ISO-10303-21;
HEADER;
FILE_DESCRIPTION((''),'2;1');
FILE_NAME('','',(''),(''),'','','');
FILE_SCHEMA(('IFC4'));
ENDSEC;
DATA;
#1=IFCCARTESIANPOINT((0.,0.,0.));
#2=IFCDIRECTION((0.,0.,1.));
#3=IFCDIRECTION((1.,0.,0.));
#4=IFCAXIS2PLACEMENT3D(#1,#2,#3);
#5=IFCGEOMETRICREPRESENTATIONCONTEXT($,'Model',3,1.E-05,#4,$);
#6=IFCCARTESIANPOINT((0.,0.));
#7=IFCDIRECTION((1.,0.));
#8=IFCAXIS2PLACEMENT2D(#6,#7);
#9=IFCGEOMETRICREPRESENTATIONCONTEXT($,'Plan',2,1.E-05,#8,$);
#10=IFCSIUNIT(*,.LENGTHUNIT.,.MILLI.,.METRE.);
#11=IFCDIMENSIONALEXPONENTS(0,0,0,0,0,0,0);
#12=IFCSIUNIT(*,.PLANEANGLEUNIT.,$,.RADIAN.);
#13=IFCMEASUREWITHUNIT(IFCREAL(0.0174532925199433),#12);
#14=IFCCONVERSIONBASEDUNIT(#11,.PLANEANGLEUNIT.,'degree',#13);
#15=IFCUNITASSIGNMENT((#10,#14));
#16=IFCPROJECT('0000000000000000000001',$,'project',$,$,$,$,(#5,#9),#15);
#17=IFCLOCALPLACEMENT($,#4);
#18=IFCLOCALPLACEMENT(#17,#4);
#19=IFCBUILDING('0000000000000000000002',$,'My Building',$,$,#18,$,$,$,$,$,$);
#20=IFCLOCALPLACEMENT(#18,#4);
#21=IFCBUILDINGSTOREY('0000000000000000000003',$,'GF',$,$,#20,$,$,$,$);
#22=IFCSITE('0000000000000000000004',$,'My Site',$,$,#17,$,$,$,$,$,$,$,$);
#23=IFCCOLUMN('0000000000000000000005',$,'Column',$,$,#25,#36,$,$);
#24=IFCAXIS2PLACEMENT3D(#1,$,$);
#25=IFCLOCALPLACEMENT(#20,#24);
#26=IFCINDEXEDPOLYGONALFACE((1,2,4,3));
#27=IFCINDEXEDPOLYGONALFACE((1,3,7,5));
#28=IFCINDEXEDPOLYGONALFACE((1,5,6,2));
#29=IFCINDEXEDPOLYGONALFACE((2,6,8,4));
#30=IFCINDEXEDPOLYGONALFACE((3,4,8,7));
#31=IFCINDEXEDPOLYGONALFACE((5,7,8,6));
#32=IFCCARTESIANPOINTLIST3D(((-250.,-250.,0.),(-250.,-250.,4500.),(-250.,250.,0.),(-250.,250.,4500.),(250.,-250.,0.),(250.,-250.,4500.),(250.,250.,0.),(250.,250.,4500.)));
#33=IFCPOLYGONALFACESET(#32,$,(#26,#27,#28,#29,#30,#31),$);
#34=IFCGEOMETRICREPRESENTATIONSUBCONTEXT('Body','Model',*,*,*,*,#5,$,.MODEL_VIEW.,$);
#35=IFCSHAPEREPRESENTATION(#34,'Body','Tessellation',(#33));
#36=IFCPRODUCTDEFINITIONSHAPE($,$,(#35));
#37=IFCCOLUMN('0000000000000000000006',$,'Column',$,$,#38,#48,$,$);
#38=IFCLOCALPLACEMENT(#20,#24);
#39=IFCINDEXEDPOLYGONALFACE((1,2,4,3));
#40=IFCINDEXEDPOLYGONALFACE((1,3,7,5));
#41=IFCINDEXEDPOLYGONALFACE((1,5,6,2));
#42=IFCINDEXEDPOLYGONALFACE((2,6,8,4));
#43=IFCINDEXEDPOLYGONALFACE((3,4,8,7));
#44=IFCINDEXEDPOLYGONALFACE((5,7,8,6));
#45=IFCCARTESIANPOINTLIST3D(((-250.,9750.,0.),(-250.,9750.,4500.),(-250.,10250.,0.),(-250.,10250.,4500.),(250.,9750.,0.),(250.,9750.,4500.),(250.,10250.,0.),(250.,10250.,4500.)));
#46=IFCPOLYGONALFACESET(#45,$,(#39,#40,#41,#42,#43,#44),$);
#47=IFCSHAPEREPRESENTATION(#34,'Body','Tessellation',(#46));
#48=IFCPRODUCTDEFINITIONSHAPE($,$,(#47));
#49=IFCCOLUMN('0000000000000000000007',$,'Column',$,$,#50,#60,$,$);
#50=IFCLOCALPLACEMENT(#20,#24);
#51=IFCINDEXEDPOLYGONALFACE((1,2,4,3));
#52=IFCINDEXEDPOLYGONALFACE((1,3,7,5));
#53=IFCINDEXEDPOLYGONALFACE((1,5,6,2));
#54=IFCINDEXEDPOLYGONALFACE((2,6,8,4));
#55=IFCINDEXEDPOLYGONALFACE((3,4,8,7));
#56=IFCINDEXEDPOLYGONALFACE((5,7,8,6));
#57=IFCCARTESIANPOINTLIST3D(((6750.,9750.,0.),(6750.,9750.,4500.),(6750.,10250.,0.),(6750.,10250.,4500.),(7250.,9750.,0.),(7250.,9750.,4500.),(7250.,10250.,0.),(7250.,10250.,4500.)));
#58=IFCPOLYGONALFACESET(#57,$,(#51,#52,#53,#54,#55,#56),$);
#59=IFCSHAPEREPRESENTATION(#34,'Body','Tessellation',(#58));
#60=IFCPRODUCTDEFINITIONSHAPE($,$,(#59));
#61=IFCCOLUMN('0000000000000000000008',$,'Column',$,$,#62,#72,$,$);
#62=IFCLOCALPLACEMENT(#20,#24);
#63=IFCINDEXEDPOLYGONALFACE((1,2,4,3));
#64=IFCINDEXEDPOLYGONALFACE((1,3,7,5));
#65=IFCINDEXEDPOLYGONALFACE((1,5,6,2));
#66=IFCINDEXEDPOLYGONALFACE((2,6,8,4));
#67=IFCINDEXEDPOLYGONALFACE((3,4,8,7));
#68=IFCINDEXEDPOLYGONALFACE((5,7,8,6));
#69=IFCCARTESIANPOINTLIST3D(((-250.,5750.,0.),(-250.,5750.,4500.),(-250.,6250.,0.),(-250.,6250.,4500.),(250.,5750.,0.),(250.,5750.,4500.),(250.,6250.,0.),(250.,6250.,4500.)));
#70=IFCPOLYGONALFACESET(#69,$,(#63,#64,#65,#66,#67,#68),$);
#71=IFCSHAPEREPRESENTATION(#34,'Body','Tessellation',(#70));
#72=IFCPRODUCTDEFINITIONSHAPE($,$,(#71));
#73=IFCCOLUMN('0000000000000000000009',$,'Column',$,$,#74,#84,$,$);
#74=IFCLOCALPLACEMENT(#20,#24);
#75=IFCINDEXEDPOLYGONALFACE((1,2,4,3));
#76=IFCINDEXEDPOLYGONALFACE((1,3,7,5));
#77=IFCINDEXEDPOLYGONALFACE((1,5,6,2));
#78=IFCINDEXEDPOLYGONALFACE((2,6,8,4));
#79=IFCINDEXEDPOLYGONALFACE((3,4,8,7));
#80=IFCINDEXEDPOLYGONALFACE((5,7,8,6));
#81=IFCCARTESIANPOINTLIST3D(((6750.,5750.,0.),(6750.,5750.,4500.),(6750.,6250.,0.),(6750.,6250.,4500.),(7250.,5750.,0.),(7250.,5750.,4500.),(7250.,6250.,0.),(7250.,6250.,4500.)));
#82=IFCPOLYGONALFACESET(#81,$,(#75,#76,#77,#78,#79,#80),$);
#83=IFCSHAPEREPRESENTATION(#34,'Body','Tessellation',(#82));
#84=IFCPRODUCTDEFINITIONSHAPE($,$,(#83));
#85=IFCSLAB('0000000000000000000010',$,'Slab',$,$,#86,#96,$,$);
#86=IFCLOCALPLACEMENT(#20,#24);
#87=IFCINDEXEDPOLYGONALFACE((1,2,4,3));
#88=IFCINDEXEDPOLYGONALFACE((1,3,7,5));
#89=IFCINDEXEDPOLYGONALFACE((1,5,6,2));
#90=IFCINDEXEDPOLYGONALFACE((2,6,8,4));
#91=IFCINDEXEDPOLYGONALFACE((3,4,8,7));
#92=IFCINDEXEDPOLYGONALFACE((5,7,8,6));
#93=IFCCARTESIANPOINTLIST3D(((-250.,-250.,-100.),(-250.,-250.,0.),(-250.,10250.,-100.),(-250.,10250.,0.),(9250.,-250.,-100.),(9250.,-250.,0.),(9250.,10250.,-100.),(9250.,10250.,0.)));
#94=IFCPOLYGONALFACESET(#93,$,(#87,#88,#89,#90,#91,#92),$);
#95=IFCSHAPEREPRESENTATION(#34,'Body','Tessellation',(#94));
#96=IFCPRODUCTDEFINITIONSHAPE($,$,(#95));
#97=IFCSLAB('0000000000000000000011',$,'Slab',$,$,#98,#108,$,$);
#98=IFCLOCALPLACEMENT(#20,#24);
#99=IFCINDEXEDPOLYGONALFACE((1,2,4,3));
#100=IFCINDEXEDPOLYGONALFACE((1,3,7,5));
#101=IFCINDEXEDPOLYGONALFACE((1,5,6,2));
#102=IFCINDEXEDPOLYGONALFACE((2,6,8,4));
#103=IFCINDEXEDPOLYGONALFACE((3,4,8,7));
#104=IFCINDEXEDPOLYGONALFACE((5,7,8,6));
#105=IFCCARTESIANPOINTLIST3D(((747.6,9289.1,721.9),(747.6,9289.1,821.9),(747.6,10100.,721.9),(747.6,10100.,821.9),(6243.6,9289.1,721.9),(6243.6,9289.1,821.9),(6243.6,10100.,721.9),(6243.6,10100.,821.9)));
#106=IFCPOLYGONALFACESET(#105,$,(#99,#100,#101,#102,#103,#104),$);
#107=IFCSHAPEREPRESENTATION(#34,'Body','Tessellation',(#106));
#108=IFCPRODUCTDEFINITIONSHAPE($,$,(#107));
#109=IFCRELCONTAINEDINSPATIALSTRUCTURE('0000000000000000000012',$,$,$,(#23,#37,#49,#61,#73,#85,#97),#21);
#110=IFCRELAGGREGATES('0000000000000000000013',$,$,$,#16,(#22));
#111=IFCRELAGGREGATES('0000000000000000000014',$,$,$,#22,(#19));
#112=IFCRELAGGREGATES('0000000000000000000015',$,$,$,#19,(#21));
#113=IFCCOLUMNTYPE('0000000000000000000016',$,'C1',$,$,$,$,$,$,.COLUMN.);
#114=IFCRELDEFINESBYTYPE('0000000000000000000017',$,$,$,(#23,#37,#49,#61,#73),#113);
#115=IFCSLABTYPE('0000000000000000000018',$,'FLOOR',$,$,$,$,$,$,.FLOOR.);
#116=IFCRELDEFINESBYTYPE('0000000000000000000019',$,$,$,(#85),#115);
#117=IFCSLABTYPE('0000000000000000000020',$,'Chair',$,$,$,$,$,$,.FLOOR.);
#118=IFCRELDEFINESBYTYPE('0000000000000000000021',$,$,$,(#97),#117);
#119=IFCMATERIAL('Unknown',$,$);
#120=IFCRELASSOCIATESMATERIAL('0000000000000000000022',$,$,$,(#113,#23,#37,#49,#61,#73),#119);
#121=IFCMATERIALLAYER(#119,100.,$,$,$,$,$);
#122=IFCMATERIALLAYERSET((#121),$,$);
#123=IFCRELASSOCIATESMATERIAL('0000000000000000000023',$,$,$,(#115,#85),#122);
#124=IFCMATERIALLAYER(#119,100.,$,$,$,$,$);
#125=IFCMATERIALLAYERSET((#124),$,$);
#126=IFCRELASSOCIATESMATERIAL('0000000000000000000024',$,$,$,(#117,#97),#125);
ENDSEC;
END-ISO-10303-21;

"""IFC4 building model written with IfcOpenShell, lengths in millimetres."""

from ifc_helpers import new_model, entity, si_unit, converted_unit, frame, origin_with_axes, origin_2d_with_axis, place, context, subcontext, project, spatial, indexed_curve, rectangle, outline, extrude, material, layer, layer_set, layer_usage, material_profile, profile_set, profile_usage, type_object, element, save


model = new_model("IFC4")

# Units and contexts
model_context = context("Model", 3, precision=1e-05, world=origin_with_axes())
plan_context = context("Plan", 2, precision=1e-05, world=origin_2d_with_axis())
body_context_1 = subcontext(model_context, "Body", "Model", "MODEL_VIEW")
ifc_project = project(units=[si_unit("LENGTHUNIT", "METRE", prefix="MILLI"), converted_unit("PLANEANGLEUNIT", "degree", entity("IfcReal", 0.0174532925199433), si_unit("PLANEANGLEUNIT", "RADIAN"), dimensions=[0, 0, 0, 0, 0, 0, 0])], contexts=[model_context, plan_context])

# Site, building, storey
site_placement = place(None, origin_with_axes())
site = spatial("IfcSite", under=ifc_project, at=site_placement, Name="My Site")
building_placement = place(site_placement, origin_with_axes())
building = spatial("IfcBuilding", under=site, at=building_placement, Name="My Building")
storey_placement = place(building_placement, origin_with_axes())
storey = spatial("IfcBuildingStorey", under=building, at=storey_placement, Name="GF")

# Columns
ifc_material = material(Name="Unknown")
ifc_material_profile = material_profile(ifc_material, rectangle(XDim=500.0, YDim=500.0))
ifc_profile_set = profile_set([ifc_material_profile])
ifc_profile_usage_1 = profile_usage(ifc_profile_set, cardinal=5)
column_type = type_object("IfcColumnType", Name="C1", PredefinedType="COLUMN", material=ifc_profile_set)
column_1_placement = place(storey_placement, origin_with_axes())
element("IfcColumn", 1, at=column_1_placement, inside=storey, type_object=column_type, material=ifc_profile_usage_1, Name="Column", context=body_context_1, shape_type="SweptSolid", body=[
    extrude(rectangle(XDim=500.0, YDim=500.0), origin_with_axes(), (0.0, 0.0, 1.0), 4500.0),
])
ifc_profile_usage_2 = profile_usage(ifc_profile_set, cardinal=5)
column_2_placement = place(storey_placement, frame((0.0, 10000.0, 0.0), z_axis=(0.0, 0.0, 1.0), x_axis=(1.0, 0.0, 0.0)))
element("IfcColumn", 2, at=column_2_placement, inside=storey, type_object=column_type, material=ifc_profile_usage_2, Name="Column", context=body_context_1, shape_type="SweptSolid", body=[
    extrude(rectangle(XDim=500.0, YDim=500.0), origin_with_axes(), (0.0, 0.0, 1.0), 4500.0),
])
ifc_profile_usage_3 = profile_usage(ifc_profile_set, cardinal=5)
column_3_placement = place(storey_placement, frame((7000.0, 10000.0, 0.0), z_axis=(0.0, 0.0, 1.0), x_axis=(1.0, 0.0, 0.0)))
element("IfcColumn", 3, at=column_3_placement, inside=storey, type_object=column_type, material=ifc_profile_usage_3, Name="Column", context=body_context_1, shape_type="SweptSolid", body=[
    extrude(rectangle(XDim=500.0, YDim=500.0), origin_with_axes(), (0.0, 0.0, 1.0), 4500.0),
])
ifc_profile_usage_4 = profile_usage(ifc_profile_set, cardinal=5)
column_4_placement = place(storey_placement, frame((0.0, 6000.0, 0.0), z_axis=(0.0, 0.0, 1.0), x_axis=(1.0, 0.0, 0.0)))
element("IfcColumn", 4, at=column_4_placement, inside=storey, type_object=column_type, material=ifc_profile_usage_4, Name="Column", context=body_context_1, shape_type="SweptSolid", body=[
    extrude(rectangle(XDim=500.0, YDim=500.0), origin_with_axes(), (0.0, 0.0, 1.0), 4500.0),
])
ifc_profile_usage_5 = profile_usage(ifc_profile_set, cardinal=5)
column_5_placement = place(storey_placement, frame((7000.0, 6000.0, 0.0), z_axis=(0.0, 0.0, 1.0), x_axis=(1.0, 0.0, 0.0)))
element("IfcColumn", 5, at=column_5_placement, inside=storey, type_object=column_type, material=ifc_profile_usage_5, Name="Column", context=body_context_1, shape_type="SweptSolid", body=[
    extrude(rectangle(XDim=500.0, YDim=500.0), origin_with_axes(), (0.0, 0.0, 1.0), 4500.0),
])

# Slabs
ifc_layer_1 = layer(ifc_material, 100.0)
ifc_layer_set_1 = layer_set([ifc_layer_1])
ifc_layer_usage_1 = layer_usage(ifc_layer_set_1, "AXIS3", "POSITIVE", -100.0)
slab_type_1 = type_object("IfcSlabType", Name="FLOOR", PredefinedType="FLOOR", material=ifc_layer_set_1)
slab_1_placement = place(storey_placement, frame((-250.0, 10250.0, 0.0), z_axis=(0.0, 0.0, 1.0), x_axis=(1.0, 0.0, 0.0)))
element("IfcSlab", 6, at=slab_1_placement, inside=storey, type_object=slab_type_1, material=ifc_layer_usage_1, Name="Slab", context=body_context_1, shape_type="SweptSolid", body=[
    extrude(outline(indexed_curve([(0.0, 0.0), (9500.0, 0.0), (9500.0, -10500.0), (0.0, -10500.0), (0.0, 0.0)])), frame((0.0, 0.0, -100.0), z_axis=(0.0, 0.0, 1.0), x_axis=(1.0, 0.0, 0.0)), (0.0, 0.0, 1.0), 100.0),
])
ifc_layer_2 = layer(ifc_material, 100.0)
ifc_layer_set_2 = layer_set([ifc_layer_2])
ifc_layer_usage_2 = layer_usage(ifc_layer_set_2, "AXIS3", "POSITIVE", -100.0)
slab_type_2 = type_object("IfcSlabType", Name="Chair", PredefinedType="FLOOR", material=ifc_layer_set_2)
slab_2_placement = place(storey_placement, frame((747.6, 10100.0, 821.9), z_axis=(0.0, 0.0, 1.0), x_axis=(1.0, 0.0, 0.0)))
element("IfcSlab", 7, at=slab_2_placement, inside=storey, type_object=slab_type_2, material=ifc_layer_usage_2, Name="Slab", context=body_context_1, shape_type="SweptSolid", body=[
    extrude(outline(indexed_curve([(0.0, 0.0), (5496.0, 0.0), (5496.0, -810.9), (-0.1, -810.9), (0.0, 0.0)])), frame((0.0, 0.0, -100.0), z_axis=(0.0, 0.0, 1.0), x_axis=(1.0, 0.0, 0.0)), (0.0, 0.0, 1.0), 100.0),
])

save(model, "model.ifc")
